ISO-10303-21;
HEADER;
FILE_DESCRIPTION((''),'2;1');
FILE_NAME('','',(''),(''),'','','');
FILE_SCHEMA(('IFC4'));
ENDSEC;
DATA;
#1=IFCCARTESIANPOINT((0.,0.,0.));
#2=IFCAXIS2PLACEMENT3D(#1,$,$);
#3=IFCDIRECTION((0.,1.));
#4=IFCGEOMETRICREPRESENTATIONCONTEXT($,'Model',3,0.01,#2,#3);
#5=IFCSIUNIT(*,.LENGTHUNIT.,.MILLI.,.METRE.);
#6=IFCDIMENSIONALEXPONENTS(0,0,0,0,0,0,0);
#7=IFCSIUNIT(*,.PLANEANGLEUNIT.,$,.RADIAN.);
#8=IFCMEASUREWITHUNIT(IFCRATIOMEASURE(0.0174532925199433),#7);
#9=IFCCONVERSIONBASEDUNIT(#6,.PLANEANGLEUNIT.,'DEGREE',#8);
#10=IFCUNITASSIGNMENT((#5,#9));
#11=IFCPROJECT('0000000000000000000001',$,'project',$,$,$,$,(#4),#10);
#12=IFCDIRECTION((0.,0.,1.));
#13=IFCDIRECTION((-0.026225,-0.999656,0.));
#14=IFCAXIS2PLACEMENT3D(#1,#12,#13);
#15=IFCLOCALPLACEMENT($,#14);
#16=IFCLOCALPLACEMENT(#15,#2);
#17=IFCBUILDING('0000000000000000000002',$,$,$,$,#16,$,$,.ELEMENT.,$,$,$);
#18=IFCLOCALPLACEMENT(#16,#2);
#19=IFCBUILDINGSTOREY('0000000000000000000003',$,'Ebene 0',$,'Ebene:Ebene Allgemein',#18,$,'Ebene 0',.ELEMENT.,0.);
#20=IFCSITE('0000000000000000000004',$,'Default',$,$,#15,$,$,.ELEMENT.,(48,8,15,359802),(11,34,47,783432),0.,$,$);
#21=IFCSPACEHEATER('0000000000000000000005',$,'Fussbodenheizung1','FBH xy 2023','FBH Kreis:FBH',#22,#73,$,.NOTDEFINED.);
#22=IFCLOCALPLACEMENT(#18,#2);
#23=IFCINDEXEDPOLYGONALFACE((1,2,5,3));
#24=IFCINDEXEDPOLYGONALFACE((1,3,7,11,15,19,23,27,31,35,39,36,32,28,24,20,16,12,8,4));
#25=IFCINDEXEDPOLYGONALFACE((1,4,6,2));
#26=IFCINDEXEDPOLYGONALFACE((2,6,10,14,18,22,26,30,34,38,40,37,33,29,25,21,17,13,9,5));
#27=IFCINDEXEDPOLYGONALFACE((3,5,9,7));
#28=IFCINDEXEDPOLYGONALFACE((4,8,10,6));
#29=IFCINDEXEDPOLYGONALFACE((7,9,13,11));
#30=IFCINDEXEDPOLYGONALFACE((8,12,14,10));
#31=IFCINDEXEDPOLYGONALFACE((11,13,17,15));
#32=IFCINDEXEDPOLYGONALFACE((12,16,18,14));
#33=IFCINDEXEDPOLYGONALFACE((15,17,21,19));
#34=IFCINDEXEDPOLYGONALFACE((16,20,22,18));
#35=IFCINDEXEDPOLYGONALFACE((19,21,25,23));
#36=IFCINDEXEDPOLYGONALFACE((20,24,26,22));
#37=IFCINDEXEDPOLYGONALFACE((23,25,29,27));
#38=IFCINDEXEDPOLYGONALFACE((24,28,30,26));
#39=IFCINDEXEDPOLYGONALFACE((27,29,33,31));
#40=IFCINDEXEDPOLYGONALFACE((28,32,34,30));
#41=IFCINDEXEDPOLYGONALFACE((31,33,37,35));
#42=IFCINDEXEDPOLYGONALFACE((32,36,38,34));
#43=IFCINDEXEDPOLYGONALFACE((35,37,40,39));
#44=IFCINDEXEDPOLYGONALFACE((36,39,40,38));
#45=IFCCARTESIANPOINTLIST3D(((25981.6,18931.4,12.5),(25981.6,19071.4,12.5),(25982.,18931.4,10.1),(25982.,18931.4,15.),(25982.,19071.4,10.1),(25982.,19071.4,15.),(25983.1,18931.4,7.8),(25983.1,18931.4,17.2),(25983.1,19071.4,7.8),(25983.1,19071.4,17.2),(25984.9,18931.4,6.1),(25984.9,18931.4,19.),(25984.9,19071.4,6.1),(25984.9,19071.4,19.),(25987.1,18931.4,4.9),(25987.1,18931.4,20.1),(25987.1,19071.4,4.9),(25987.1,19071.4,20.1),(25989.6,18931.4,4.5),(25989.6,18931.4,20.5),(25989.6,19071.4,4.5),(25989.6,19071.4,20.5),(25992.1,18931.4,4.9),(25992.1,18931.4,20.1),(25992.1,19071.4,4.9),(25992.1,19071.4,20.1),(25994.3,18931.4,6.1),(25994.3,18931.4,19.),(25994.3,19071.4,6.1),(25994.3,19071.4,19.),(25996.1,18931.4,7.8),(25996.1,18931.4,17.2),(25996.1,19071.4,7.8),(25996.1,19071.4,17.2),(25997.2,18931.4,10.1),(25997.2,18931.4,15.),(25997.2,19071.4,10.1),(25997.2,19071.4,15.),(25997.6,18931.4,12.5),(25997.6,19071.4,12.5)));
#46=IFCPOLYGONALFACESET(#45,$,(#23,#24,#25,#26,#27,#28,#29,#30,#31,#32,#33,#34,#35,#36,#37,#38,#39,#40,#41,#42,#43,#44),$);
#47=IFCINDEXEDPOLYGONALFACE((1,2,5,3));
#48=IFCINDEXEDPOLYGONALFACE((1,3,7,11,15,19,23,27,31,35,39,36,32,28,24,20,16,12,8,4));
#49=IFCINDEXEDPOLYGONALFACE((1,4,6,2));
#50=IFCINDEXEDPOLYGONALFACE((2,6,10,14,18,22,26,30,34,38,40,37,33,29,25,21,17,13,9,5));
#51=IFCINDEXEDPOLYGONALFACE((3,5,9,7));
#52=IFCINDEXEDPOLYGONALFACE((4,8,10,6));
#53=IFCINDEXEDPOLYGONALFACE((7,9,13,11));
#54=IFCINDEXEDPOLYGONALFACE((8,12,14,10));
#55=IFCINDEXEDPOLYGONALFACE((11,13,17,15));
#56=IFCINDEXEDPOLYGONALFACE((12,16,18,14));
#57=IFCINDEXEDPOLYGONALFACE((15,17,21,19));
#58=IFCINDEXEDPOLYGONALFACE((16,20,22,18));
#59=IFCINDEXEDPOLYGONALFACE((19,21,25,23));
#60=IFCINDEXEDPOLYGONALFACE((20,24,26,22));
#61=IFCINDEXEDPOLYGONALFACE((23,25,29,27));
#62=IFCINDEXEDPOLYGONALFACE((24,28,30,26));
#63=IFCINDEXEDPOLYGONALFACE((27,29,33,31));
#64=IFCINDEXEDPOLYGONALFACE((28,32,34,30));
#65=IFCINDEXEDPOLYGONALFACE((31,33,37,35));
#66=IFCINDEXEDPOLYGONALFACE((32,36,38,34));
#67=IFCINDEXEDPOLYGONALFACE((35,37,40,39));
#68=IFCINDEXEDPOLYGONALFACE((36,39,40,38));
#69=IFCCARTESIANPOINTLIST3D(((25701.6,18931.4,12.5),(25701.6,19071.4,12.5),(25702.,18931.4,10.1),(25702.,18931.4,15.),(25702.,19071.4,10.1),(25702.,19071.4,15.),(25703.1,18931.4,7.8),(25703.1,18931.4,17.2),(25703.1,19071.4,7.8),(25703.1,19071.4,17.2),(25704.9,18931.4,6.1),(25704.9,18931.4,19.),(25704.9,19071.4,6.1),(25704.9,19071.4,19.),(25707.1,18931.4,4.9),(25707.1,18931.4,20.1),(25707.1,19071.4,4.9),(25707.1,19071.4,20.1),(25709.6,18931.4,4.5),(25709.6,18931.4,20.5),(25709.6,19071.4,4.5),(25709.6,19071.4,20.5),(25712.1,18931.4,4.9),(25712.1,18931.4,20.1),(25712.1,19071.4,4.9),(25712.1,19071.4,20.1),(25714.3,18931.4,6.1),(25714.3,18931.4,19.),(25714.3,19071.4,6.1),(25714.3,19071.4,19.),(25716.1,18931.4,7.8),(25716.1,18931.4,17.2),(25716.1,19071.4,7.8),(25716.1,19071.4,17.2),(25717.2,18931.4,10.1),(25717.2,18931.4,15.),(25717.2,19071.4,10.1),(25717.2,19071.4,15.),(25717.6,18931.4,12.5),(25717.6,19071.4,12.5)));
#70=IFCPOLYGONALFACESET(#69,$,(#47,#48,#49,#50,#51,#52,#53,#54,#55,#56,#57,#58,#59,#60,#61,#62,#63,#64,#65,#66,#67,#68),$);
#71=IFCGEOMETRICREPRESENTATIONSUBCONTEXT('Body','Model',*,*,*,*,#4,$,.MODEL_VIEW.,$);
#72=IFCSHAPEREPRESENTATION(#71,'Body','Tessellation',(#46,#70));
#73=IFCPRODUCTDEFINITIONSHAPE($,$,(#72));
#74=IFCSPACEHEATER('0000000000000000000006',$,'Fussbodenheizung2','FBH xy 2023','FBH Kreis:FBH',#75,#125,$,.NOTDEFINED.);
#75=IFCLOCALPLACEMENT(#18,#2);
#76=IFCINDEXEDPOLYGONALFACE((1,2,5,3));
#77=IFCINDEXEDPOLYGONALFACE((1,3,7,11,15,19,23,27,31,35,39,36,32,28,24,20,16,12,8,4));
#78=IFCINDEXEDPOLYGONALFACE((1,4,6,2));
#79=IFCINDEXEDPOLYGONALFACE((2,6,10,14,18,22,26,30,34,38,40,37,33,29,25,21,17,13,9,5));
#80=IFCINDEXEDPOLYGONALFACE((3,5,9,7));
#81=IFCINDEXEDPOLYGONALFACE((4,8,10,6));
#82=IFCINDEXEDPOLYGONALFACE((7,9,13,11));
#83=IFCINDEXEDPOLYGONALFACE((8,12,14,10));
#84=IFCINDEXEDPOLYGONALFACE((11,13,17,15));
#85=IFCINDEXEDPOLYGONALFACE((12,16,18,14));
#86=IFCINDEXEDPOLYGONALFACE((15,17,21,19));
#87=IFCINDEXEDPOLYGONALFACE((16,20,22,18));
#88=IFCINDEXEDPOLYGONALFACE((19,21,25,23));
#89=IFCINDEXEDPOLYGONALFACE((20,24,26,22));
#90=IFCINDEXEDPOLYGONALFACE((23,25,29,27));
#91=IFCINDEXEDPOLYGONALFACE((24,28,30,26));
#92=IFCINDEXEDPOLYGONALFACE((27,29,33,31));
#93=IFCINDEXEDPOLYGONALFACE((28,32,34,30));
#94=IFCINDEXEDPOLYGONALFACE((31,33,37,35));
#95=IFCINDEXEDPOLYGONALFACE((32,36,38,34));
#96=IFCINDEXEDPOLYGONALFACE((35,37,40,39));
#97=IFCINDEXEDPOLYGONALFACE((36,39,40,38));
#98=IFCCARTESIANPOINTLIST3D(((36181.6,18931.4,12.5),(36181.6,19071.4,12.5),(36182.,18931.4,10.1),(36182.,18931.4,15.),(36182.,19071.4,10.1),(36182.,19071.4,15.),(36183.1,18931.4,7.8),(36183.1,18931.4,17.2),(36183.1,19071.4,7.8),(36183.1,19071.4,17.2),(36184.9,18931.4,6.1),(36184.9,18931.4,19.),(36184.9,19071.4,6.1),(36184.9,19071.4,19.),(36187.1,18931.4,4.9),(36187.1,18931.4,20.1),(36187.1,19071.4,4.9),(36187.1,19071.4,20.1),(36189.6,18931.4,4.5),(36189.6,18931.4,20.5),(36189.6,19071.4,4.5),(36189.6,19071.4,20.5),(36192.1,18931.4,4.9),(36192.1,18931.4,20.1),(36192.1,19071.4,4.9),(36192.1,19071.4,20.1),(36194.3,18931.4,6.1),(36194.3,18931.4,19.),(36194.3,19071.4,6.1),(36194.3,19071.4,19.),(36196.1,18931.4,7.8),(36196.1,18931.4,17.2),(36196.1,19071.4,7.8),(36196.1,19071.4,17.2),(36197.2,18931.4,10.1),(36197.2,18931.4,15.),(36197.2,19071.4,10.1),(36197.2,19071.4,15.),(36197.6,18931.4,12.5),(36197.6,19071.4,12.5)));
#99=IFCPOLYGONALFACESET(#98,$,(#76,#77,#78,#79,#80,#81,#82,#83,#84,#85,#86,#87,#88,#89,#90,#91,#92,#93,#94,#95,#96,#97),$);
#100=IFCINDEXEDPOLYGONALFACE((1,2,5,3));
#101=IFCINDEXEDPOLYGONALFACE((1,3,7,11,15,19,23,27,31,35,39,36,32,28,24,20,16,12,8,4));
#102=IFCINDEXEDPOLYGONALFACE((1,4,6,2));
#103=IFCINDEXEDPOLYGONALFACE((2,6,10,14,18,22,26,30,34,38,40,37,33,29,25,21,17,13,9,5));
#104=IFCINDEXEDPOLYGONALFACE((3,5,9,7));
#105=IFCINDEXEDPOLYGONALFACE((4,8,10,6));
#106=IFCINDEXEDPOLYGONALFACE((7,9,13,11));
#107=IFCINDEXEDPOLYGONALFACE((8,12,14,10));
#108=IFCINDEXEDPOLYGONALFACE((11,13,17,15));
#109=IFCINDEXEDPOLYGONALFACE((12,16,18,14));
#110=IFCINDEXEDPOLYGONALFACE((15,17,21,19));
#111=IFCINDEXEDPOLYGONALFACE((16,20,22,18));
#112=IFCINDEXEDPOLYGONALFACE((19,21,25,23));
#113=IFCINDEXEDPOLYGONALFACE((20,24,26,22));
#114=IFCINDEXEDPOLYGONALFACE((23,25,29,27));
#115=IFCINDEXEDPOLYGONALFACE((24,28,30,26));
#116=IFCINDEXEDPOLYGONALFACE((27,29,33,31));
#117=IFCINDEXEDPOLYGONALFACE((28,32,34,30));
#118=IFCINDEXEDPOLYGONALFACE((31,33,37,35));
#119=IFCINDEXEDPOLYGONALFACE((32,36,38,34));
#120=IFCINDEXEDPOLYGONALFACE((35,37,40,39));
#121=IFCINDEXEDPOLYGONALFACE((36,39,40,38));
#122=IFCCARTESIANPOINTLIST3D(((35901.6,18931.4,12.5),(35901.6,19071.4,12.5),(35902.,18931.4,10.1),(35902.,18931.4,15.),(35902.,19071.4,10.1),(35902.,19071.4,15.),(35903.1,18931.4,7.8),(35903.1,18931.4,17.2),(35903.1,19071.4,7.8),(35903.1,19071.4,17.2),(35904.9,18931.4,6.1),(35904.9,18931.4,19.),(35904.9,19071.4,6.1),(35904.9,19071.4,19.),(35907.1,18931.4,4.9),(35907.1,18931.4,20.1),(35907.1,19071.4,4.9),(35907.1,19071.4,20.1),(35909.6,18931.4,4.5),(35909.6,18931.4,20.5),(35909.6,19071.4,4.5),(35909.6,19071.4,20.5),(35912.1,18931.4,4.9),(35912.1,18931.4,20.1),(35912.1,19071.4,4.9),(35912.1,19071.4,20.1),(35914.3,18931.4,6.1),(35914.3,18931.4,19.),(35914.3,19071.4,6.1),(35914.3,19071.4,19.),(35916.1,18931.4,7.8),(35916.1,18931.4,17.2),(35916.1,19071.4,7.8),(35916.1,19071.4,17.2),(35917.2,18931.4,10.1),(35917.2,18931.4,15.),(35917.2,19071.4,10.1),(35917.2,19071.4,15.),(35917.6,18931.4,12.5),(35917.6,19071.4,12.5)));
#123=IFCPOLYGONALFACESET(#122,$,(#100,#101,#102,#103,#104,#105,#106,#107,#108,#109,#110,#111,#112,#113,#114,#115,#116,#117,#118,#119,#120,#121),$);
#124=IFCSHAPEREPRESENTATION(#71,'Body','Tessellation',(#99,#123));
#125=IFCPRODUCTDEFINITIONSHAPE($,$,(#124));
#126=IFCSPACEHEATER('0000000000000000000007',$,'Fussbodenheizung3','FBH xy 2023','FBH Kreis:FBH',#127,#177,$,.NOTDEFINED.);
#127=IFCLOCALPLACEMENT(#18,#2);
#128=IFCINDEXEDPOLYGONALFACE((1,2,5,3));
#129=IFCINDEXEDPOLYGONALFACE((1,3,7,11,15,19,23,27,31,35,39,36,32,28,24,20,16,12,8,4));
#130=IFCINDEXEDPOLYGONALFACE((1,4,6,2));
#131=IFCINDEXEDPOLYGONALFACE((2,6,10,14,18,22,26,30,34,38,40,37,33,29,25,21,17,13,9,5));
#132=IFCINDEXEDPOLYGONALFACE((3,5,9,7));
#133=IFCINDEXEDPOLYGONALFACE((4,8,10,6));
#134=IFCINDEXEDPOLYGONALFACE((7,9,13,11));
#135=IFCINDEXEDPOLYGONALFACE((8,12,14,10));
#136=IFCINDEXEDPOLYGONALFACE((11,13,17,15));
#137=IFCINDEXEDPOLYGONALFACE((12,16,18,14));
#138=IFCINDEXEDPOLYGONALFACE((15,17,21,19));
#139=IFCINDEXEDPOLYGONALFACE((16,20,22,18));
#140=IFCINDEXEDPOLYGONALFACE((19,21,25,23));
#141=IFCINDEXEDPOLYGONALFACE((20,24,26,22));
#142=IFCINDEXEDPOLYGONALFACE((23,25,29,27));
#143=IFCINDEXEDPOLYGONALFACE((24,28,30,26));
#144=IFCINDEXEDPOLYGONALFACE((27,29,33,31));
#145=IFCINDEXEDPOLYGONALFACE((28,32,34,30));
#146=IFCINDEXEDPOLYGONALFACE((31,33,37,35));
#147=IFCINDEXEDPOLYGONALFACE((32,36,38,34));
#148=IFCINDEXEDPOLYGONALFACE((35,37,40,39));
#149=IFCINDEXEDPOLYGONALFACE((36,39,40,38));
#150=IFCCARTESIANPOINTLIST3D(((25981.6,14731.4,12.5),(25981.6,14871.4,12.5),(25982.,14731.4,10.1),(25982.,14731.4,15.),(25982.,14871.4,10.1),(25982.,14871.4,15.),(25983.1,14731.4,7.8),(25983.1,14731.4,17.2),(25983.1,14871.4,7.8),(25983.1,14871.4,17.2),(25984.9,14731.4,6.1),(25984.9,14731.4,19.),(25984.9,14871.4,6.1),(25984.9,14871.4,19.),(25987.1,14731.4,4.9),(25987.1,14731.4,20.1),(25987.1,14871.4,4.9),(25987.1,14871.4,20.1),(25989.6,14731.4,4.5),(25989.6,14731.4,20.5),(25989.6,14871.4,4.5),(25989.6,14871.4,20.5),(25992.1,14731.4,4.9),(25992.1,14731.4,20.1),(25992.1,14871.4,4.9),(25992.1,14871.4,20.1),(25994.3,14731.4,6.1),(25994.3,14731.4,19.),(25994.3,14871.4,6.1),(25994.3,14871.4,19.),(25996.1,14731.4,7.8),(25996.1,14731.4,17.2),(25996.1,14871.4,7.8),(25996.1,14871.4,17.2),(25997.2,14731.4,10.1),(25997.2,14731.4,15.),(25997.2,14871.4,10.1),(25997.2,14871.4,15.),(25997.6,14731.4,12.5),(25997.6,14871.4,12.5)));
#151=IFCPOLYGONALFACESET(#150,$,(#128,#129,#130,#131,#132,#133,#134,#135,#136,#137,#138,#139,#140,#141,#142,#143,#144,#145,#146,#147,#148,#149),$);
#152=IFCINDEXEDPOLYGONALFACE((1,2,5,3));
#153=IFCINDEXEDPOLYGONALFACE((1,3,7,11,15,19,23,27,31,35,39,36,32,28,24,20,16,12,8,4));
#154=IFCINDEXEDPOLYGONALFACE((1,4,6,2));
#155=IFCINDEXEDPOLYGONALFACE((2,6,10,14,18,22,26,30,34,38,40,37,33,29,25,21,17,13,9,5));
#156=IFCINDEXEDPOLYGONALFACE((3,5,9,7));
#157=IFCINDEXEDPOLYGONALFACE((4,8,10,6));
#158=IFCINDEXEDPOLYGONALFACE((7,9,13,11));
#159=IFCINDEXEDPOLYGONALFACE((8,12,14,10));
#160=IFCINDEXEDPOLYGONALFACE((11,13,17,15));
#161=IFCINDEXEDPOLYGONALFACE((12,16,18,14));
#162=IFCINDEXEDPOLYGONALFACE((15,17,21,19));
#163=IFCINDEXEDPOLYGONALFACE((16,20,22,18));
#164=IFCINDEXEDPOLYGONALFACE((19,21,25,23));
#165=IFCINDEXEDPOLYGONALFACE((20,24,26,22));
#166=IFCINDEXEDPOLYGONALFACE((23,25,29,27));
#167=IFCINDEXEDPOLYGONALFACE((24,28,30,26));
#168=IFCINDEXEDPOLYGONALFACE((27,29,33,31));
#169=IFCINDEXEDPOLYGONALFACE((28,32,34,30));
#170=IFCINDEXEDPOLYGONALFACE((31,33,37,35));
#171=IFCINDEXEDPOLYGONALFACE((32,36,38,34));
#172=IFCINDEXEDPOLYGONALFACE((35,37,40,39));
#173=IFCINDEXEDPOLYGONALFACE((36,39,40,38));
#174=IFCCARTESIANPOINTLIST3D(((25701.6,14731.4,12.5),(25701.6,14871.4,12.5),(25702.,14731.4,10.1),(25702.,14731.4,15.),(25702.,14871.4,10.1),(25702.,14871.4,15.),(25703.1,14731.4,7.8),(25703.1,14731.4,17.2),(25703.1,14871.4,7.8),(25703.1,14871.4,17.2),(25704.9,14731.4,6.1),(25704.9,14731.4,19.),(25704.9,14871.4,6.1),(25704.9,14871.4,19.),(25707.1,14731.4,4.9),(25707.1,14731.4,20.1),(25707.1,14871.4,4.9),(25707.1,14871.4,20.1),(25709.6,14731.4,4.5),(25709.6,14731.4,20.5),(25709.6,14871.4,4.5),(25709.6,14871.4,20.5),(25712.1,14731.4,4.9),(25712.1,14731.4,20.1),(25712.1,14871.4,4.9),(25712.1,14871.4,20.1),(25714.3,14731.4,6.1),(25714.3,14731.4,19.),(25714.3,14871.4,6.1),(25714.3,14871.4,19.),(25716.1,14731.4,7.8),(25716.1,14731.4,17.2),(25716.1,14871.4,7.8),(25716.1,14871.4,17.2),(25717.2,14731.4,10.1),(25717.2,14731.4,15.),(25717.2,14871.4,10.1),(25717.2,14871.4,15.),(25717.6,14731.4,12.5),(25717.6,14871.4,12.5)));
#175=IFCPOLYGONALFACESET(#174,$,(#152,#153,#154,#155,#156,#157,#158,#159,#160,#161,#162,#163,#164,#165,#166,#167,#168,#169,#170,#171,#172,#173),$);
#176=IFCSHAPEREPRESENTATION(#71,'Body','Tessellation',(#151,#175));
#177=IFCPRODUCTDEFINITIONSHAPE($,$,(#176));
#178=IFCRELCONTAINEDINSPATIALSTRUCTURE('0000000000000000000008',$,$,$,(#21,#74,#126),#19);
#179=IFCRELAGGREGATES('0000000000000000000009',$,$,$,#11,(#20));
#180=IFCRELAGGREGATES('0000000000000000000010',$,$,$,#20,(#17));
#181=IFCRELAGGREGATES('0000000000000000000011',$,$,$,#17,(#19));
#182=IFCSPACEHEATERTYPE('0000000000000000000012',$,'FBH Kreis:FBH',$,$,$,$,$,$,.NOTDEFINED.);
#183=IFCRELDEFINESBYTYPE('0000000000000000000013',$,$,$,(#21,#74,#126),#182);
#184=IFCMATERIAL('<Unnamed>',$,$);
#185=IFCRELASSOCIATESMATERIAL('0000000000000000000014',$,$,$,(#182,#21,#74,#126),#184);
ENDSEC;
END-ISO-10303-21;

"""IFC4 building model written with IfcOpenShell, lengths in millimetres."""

from ifc_helpers import new_model, entity, si_unit, converted_unit, direction, frame, origin, place, context, subcontext, project, spatial, indexed_curve, outline, extrude, source, transform, mapped, material, type_object, type_shapes, element, save


model = new_model("IFC4")

# Units and contexts
model_context = context("Model", 3, precision=0.01, world=origin(), true_north=direction((0.0, 1.0)))
body_context = subcontext(model_context, "Body", "Model", "MODEL_VIEW")
ifc_project = project(units=[si_unit("LENGTHUNIT", "METRE", prefix="MILLI"), converted_unit("PLANEANGLEUNIT", "DEGREE", entity("IfcRatioMeasure", 0.0174532925199433), si_unit("PLANEANGLEUNIT", "RADIAN"), dimensions=[0, 0, 0, 0, 0, 0, 0])], contexts=[model_context])

# Site, building, storey
site_placement = place(None, frame((0.0, 0.0, 0.0), z_axis=(0.0, 0.0, 1.0), x_axis=(-0.026225, -0.999656, 0.0)))
site = spatial("IfcSite", under=ifc_project, at=site_placement, Name="Default", CompositionType="ELEMENT", RefLatitude=(48, 8, 15, 359802), RefLongitude=(11, 34, 47, 783432), RefElevation=0.0)
building_placement = place(site_placement, origin())
building = spatial("IfcBuilding", under=site, at=building_placement, CompositionType="ELEMENT")
storey_placement = place(building_placement, origin())
storey = spatial("IfcBuildingStorey", under=building, at=storey_placement, Name="Ebene 0", ObjectType="Ebene:Ebene Allgemein", LongName="Ebene 0", CompositionType="ELEMENT", Elevation=0.0)

# Space heaters
ifc_material = material(Name="<Unnamed>")
space_heater_type = type_object("IfcSpaceHeaterType", Name="FBH Kreis:FBH", PredefinedType="NOTDEFINED", material=ifc_material)
shared_shape = source(origin(), body_context, "Body", "SweptSolid", [
    extrude(outline(indexed_curve([(8.0, 0.0), (7.6, 2.5), (6.5, 4.7), (4.7, 6.5), (2.5, 7.6), (0.0, 8.0), (-2.5, 7.6), (-4.7, 6.5), (-6.5, 4.7), (-7.6, 2.5), (-8.0, 0.0), (-7.6, -2.5), (-6.5, -4.7), (-4.7, -6.5), (-2.5, -7.6), (0.0, -8.0), (2.5, -7.6), (4.7, -6.5), (6.5, -4.7), (7.6, -2.5), (8.0, 0.0)], self_intersect=False)), frame((140.0, -1621.8, -83.0), z_axis=(0.0, 1.0, 0.0), x_axis=(1.0, 0.0, 0.0)), (0.0, 0.0, 1.0), 140.0),
    extrude(outline(indexed_curve([(8.0, 0.0), (7.6, 2.5), (6.5, 4.7), (4.7, 6.5), (2.5, 7.6), (0.0, 8.0), (-2.5, 7.6), (-4.7, 6.5), (-6.5, 4.7), (-7.6, 2.5), (-8.0, 0.0), (-7.6, -2.5), (-6.5, -4.7), (-4.7, -6.5), (-2.5, -7.6), (0.0, -8.0), (2.5, -7.6), (4.7, -6.5), (6.5, -4.7), (7.6, -2.5), (8.0, 0.0)], self_intersect=False)), frame((-140.0, -1621.8, -83.0), z_axis=(0.0, 1.0, 0.0), x_axis=(1.0, 0.0, 0.0)), (0.0, 0.0, 1.0), 140.0),
])
type_shapes(space_heater_type, [shared_shape])
for number, where, name in (
    (1, (25849.6, 20553.2, 95.5), "Fussbodenheizung1"),
    (2, (36049.6, 20553.2, 95.5), "Fussbodenheizung2"),
    (3, (25849.6, 16353.2, 95.5), "Fussbodenheizung3"),
):
    element("IfcSpaceHeater", number, at=place(storey_placement, frame(where)), inside=storey, type_object=space_heater_type, material=ifc_material, Name=name, Description="FBH xy 2023", ObjectType="FBH Kreis:FBH", PredefinedType="NOTDEFINED", context=body_context, shape_type="MappedRepresentation", body=[
        mapped(shared_shape, transform((0.0, 0.0, 0.0), scale=1.0)),
    ])

save(model, "model.ifc")
